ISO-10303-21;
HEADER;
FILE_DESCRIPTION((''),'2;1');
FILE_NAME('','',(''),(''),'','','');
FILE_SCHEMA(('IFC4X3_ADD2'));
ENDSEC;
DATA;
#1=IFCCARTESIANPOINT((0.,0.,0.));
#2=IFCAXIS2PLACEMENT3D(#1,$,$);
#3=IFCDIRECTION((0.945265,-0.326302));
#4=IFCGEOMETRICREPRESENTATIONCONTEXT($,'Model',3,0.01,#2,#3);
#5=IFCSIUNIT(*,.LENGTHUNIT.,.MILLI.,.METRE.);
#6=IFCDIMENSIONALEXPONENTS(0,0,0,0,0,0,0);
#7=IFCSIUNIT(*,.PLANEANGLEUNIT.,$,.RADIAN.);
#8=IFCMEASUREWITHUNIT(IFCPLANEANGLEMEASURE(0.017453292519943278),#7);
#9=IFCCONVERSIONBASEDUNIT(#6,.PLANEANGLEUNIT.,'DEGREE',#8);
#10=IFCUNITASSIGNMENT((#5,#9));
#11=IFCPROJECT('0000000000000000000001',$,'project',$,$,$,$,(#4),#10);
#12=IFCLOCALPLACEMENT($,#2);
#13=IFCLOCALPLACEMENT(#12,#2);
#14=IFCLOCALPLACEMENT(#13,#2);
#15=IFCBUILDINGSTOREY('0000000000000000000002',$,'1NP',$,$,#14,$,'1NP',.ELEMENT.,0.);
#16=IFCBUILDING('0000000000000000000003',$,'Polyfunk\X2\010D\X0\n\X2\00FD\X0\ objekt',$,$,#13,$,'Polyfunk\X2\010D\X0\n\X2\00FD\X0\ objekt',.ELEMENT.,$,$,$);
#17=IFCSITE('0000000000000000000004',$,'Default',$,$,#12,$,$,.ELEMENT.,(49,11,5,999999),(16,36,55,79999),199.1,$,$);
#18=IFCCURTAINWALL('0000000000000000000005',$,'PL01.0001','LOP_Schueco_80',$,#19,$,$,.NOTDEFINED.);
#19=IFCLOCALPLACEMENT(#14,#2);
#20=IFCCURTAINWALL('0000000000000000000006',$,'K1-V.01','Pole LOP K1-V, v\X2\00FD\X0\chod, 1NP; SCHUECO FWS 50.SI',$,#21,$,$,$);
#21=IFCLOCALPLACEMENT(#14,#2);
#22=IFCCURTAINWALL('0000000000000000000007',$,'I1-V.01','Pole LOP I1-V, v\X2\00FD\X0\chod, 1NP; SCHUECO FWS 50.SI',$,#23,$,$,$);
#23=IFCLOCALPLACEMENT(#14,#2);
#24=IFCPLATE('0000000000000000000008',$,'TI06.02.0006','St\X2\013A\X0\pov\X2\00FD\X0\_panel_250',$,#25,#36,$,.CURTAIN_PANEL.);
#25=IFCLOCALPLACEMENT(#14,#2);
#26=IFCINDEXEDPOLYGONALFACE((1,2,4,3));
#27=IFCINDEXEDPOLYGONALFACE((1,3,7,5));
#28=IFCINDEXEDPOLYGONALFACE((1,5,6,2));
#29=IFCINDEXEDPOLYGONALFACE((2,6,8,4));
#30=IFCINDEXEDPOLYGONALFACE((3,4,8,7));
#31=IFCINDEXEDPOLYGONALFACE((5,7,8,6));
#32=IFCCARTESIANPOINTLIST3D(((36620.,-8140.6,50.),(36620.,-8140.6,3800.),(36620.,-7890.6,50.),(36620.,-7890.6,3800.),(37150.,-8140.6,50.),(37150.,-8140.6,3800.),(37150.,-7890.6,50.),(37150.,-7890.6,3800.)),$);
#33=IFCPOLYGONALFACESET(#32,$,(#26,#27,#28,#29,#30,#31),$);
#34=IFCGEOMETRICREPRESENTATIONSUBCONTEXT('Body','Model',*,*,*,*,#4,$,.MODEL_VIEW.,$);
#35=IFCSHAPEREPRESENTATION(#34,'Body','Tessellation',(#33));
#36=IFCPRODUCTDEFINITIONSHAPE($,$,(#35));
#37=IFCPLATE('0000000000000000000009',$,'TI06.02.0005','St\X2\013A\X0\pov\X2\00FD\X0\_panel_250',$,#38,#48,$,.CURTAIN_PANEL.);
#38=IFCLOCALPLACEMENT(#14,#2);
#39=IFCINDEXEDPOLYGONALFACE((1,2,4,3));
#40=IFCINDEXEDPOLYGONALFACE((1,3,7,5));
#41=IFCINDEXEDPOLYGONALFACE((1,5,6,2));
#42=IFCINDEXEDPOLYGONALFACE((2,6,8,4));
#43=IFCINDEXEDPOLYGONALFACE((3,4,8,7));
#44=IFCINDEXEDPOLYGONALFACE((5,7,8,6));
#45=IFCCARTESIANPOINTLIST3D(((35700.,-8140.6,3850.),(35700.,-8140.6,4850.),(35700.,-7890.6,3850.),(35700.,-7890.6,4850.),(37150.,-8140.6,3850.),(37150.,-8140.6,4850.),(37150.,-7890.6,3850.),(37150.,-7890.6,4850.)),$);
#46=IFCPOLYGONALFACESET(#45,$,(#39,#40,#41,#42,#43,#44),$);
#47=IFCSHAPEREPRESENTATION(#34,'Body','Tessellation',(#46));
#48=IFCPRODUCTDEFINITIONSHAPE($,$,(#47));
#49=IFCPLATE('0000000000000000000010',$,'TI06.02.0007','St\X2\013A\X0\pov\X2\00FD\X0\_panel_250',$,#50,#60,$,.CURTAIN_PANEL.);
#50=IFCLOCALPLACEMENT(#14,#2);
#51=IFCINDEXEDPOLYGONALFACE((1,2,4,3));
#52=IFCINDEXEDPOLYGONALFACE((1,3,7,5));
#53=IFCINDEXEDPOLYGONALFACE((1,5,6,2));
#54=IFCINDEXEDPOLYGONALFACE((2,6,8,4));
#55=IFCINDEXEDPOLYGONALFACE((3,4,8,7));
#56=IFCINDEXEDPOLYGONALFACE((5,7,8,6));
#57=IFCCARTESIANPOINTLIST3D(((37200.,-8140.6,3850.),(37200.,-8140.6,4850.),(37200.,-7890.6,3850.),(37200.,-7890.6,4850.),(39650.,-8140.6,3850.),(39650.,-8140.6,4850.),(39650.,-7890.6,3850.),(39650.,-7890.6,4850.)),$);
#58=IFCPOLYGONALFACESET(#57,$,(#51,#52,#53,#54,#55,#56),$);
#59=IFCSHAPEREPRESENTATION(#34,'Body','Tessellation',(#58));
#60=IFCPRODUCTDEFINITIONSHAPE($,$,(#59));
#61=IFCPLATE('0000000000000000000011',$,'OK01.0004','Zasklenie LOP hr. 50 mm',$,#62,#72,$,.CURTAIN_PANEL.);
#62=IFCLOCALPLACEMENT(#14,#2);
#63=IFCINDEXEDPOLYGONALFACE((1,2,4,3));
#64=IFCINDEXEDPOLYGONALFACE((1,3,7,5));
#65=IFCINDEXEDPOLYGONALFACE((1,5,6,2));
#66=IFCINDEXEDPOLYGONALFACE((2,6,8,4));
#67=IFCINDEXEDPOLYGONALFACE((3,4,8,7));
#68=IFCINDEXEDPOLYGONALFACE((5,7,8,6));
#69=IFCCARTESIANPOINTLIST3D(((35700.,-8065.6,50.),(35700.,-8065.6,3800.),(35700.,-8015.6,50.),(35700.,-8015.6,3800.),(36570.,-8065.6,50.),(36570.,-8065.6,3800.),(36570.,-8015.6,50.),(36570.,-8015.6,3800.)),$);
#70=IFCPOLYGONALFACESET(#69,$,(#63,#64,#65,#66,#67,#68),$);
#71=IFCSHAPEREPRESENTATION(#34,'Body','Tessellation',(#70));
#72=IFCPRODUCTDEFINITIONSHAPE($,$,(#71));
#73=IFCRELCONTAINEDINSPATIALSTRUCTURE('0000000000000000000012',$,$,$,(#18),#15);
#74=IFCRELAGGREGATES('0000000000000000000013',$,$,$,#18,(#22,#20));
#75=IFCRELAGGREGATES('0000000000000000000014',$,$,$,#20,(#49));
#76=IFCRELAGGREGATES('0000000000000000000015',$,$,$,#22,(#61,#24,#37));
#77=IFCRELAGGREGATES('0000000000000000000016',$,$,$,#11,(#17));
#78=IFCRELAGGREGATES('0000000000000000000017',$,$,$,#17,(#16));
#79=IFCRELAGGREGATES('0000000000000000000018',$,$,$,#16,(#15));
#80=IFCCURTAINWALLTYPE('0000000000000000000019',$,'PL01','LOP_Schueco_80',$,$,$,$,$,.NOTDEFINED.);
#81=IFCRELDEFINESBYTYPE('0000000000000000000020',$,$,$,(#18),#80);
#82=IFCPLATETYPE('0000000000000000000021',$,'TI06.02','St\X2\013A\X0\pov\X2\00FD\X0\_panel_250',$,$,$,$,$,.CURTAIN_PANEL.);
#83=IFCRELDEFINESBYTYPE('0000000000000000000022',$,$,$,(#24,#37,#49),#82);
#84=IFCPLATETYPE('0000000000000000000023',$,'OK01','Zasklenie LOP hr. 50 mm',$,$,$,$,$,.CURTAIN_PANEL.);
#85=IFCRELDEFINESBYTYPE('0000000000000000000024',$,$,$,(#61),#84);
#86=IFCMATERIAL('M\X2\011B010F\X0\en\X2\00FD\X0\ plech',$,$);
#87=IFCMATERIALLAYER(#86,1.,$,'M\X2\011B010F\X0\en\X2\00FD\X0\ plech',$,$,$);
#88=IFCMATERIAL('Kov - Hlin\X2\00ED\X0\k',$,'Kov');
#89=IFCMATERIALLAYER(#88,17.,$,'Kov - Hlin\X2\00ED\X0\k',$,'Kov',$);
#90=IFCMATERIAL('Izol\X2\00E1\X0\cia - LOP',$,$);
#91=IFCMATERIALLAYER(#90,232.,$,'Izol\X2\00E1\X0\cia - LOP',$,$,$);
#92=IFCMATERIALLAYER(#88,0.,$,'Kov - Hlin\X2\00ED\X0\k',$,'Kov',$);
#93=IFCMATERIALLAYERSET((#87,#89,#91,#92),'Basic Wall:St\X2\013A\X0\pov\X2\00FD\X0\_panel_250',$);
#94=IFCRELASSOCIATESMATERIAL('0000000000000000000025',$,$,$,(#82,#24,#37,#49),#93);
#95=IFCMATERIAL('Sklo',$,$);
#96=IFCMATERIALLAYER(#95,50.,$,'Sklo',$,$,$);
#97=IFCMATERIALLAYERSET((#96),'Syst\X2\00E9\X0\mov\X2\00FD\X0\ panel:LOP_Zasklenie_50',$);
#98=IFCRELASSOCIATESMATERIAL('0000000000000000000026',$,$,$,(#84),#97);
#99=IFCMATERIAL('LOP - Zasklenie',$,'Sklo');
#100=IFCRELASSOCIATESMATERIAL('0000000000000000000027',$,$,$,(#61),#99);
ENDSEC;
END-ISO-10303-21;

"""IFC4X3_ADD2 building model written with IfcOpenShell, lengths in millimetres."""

from ifc_helpers import new_model, entity, si_unit, converted_unit, direction, frame, frame_2d, origin, place, context, subcontext, project, spatial, rectangle, extrude, source, transform, mapped, material, layer, layer_set, layer_usage, type_object, type_shapes, element, aggregate, save


model = new_model("IFC4X3_ADD2")

# Units and contexts
model_context = context("Model", 3, precision=0.01, world=origin(), true_north=direction((0.945265, -0.326302)))
body_context = subcontext(model_context, "Body", "Model", "MODEL_VIEW")
ifc_project = project(units=[si_unit("LENGTHUNIT", "METRE", prefix="MILLI"), converted_unit("PLANEANGLEUNIT", "DEGREE", entity("IfcPlaneAngleMeasure", 0.017453292519943278), si_unit("PLANEANGLEUNIT", "RADIAN"), dimensions=[0, 0, 0, 0, 0, 0, 0])], contexts=[model_context])

# Site, building, storey
site_placement = place(None, origin())
site = spatial("IfcSite", under=ifc_project, at=site_placement, Name="Default", CompositionType="ELEMENT", RefLatitude=(49, 11, 5, 999999), RefLongitude=(16, 36, 55, 79999), RefElevation=199.1)
building_placement = place(site_placement, origin())
building = spatial("IfcBuilding", under=site, at=building_placement, Name="Polyfunkčný objekt", LongName="Polyfunkčný objekt", CompositionType="ELEMENT")
storey_placement = place(building_placement, origin())
storey = spatial("IfcBuildingStorey", under=building, at=storey_placement, Name="1NP", LongName="1NP", CompositionType="ELEMENT", Elevation=0.0)

# Curtain walls, plates
curtain_wall_type = type_object("IfcCurtainWallType", Name="PL01", Description="LOP_Schueco_80", PredefinedType="NOTDEFINED")
curtain_wall_1_placement = place(storey_placement, origin())
curtain_wall_1 = element("IfcCurtainWall", 1, at=curtain_wall_1_placement, inside=storey, type_object=curtain_wall_type, Name="PL01.0001", Description="LOP_Schueco_80", PredefinedType="NOTDEFINED")
curtain_wall_2 = element("IfcCurtainWall", 2, Name="K1-V.01", Description="Pole LOP K1-V, východ, 1NP; SCHUECO FWS 50.SI")
curtain_wall_3 = element("IfcCurtainWall", 3, Name="I1-V.01", Description="Pole LOP I1-V, východ, 1NP; SCHUECO FWS 50.SI")
aggregate(curtain_wall_1, [curtain_wall_3, curtain_wall_2])
ifc_material_1 = material(Name="Měďený plech")
ifc_layer_1 = layer(ifc_material_1, 1.0, Name="Měďený plech")
ifc_material_2 = material(Name="Kov - Hliník", Category="Kov")
ifc_layer_2 = layer(ifc_material_2, 17.0, Name="Kov - Hliník", Category="Kov")
ifc_material_3 = material(Name="Izolácia - LOP")
ifc_layer_3 = layer(ifc_material_3, 232.0, Name="Izolácia - LOP")
ifc_layer_4 = layer(ifc_material_2, 0.0, Name="Kov - Hliník", Category="Kov")
ifc_layer_set_1 = layer_set([ifc_layer_1, ifc_layer_2, ifc_layer_3, ifc_layer_4], Name="Basic Wall:Stĺpový_panel_250")
ifc_layer_usage_1 = layer_usage(ifc_layer_set_1, "AXIS2", "POSITIVE", -125.0)
plate_type_1 = type_object("IfcPlateType", Name="TI06.02", Description="Stĺpový_panel_250", PredefinedType="CURTAIN_PANEL", material=ifc_layer_set_1)
plate_1_placement = place(storey_placement, frame((36620.0, -8015.6, 50.0)))
plate_1 = element("IfcPlate", 4, at=plate_1_placement, type_object=plate_type_1, material=ifc_layer_usage_1, Name="TI06.02.0006", Description="Stĺpový_panel_250", PredefinedType="CURTAIN_PANEL", context=body_context, shape_type="SweptSolid", body=[
    extrude(rectangle(XDim=250.0, YDim=530.0, at=frame_2d((0.0, 0.0), x_axis=(1.0, 0.0))), frame((265.0, 0.0, 0.0), z_axis=(0.0, 0.0, 1.0), x_axis=(0.0, 1.0, 0.0)), (0.0, 0.0, 1.0), 3750.0),
])
ifc_layer_usage_2 = layer_usage(ifc_layer_set_1, "AXIS2", "POSITIVE", -125.0)
plate_2_placement = place(storey_placement, frame((35700.0, -8015.6, 3850.0)))
plate_2 = element("IfcPlate", 5, at=plate_2_placement, type_object=plate_type_1, material=ifc_layer_usage_2, Name="TI06.02.0005", Description="Stĺpový_panel_250", PredefinedType="CURTAIN_PANEL", context=body_context, shape_type="SweptSolid", body=[
    extrude(rectangle(XDim=250.0, YDim=1450.0, at=frame_2d((0.0, 0.0), x_axis=(1.0, 0.0))), frame((725.0, 0.0, 0.0), z_axis=(0.0, 0.0, 1.0), x_axis=(0.0, 1.0, 0.0)), (0.0, 0.0, 1.0), 1000.0),
])
ifc_layer_usage_3 = layer_usage(ifc_layer_set_1, "AXIS2", "POSITIVE", -125.0)
plate_3_placement = place(storey_placement, frame((37200.0, -8015.6, 3850.0)))
plate_3 = element("IfcPlate", 6, at=plate_3_placement, type_object=plate_type_1, material=ifc_layer_usage_3, Name="TI06.02.0007", Description="Stĺpový_panel_250", PredefinedType="CURTAIN_PANEL", context=body_context, shape_type="SweptSolid", body=[
    extrude(rectangle(XDim=250.0, YDim=2450.0, at=frame_2d((0.0, 0.0), x_axis=(1.0, 0.0))), frame((1225.0, 0.0, 0.0), z_axis=(0.0, 0.0, 1.0), x_axis=(0.0, 1.0, 0.0)), (0.0, 0.0, 1.0), 1000.0),
])
aggregate(curtain_wall_2, [plate_3])
ifc_material_4 = material(Name="LOP - Zasklenie", Category="Sklo")
ifc_material_5 = material(Name="Sklo")
ifc_layer_5 = layer(ifc_material_5, 50.0, Name="Sklo")
ifc_layer_set_2 = layer_set([ifc_layer_5], Name="Systémový panel:LOP_Zasklenie_50")
plate_type_2 = type_object("IfcPlateType", Name="OK01", Description="Zasklenie LOP hr. 50 mm", PredefinedType="CURTAIN_PANEL", material=ifc_layer_set_2)
shared_shape_1 = source(origin(), body_context, "Body", "SweptSolid", [
    extrude(rectangle(XDim=3750.0, YDim=870.0, at=frame_2d((-331.2, 0.0), x_axis=(1.0, 0.0))), frame((0.0, -50.0, 2206.2), z_axis=(0.0, 1.0, 0.0), x_axis=(0.0, 0.0, 1.0)), (0.0, 0.0, 1.0), 50.0),
])
type_shapes(plate_type_2, [shared_shape_1])
plate_4_placement = place(curtain_wall_1_placement, frame((36135.0, -8015.6, 50.0)))
plate_4 = element("IfcPlate", 7, at=plate_4_placement, type_object=plate_type_2, material=ifc_material_4, Name="OK01.0004", Description="Zasklenie LOP hr. 50 mm", PredefinedType="CURTAIN_PANEL", context=body_context, shape_type="MappedRepresentation", body=[
    mapped(shared_shape_1, transform((0.0, 0.0, 0.0), scale=1.0)),
])
aggregate(curtain_wall_3, [plate_4, plate_1, plate_2])

save(model, "model.ifc")
